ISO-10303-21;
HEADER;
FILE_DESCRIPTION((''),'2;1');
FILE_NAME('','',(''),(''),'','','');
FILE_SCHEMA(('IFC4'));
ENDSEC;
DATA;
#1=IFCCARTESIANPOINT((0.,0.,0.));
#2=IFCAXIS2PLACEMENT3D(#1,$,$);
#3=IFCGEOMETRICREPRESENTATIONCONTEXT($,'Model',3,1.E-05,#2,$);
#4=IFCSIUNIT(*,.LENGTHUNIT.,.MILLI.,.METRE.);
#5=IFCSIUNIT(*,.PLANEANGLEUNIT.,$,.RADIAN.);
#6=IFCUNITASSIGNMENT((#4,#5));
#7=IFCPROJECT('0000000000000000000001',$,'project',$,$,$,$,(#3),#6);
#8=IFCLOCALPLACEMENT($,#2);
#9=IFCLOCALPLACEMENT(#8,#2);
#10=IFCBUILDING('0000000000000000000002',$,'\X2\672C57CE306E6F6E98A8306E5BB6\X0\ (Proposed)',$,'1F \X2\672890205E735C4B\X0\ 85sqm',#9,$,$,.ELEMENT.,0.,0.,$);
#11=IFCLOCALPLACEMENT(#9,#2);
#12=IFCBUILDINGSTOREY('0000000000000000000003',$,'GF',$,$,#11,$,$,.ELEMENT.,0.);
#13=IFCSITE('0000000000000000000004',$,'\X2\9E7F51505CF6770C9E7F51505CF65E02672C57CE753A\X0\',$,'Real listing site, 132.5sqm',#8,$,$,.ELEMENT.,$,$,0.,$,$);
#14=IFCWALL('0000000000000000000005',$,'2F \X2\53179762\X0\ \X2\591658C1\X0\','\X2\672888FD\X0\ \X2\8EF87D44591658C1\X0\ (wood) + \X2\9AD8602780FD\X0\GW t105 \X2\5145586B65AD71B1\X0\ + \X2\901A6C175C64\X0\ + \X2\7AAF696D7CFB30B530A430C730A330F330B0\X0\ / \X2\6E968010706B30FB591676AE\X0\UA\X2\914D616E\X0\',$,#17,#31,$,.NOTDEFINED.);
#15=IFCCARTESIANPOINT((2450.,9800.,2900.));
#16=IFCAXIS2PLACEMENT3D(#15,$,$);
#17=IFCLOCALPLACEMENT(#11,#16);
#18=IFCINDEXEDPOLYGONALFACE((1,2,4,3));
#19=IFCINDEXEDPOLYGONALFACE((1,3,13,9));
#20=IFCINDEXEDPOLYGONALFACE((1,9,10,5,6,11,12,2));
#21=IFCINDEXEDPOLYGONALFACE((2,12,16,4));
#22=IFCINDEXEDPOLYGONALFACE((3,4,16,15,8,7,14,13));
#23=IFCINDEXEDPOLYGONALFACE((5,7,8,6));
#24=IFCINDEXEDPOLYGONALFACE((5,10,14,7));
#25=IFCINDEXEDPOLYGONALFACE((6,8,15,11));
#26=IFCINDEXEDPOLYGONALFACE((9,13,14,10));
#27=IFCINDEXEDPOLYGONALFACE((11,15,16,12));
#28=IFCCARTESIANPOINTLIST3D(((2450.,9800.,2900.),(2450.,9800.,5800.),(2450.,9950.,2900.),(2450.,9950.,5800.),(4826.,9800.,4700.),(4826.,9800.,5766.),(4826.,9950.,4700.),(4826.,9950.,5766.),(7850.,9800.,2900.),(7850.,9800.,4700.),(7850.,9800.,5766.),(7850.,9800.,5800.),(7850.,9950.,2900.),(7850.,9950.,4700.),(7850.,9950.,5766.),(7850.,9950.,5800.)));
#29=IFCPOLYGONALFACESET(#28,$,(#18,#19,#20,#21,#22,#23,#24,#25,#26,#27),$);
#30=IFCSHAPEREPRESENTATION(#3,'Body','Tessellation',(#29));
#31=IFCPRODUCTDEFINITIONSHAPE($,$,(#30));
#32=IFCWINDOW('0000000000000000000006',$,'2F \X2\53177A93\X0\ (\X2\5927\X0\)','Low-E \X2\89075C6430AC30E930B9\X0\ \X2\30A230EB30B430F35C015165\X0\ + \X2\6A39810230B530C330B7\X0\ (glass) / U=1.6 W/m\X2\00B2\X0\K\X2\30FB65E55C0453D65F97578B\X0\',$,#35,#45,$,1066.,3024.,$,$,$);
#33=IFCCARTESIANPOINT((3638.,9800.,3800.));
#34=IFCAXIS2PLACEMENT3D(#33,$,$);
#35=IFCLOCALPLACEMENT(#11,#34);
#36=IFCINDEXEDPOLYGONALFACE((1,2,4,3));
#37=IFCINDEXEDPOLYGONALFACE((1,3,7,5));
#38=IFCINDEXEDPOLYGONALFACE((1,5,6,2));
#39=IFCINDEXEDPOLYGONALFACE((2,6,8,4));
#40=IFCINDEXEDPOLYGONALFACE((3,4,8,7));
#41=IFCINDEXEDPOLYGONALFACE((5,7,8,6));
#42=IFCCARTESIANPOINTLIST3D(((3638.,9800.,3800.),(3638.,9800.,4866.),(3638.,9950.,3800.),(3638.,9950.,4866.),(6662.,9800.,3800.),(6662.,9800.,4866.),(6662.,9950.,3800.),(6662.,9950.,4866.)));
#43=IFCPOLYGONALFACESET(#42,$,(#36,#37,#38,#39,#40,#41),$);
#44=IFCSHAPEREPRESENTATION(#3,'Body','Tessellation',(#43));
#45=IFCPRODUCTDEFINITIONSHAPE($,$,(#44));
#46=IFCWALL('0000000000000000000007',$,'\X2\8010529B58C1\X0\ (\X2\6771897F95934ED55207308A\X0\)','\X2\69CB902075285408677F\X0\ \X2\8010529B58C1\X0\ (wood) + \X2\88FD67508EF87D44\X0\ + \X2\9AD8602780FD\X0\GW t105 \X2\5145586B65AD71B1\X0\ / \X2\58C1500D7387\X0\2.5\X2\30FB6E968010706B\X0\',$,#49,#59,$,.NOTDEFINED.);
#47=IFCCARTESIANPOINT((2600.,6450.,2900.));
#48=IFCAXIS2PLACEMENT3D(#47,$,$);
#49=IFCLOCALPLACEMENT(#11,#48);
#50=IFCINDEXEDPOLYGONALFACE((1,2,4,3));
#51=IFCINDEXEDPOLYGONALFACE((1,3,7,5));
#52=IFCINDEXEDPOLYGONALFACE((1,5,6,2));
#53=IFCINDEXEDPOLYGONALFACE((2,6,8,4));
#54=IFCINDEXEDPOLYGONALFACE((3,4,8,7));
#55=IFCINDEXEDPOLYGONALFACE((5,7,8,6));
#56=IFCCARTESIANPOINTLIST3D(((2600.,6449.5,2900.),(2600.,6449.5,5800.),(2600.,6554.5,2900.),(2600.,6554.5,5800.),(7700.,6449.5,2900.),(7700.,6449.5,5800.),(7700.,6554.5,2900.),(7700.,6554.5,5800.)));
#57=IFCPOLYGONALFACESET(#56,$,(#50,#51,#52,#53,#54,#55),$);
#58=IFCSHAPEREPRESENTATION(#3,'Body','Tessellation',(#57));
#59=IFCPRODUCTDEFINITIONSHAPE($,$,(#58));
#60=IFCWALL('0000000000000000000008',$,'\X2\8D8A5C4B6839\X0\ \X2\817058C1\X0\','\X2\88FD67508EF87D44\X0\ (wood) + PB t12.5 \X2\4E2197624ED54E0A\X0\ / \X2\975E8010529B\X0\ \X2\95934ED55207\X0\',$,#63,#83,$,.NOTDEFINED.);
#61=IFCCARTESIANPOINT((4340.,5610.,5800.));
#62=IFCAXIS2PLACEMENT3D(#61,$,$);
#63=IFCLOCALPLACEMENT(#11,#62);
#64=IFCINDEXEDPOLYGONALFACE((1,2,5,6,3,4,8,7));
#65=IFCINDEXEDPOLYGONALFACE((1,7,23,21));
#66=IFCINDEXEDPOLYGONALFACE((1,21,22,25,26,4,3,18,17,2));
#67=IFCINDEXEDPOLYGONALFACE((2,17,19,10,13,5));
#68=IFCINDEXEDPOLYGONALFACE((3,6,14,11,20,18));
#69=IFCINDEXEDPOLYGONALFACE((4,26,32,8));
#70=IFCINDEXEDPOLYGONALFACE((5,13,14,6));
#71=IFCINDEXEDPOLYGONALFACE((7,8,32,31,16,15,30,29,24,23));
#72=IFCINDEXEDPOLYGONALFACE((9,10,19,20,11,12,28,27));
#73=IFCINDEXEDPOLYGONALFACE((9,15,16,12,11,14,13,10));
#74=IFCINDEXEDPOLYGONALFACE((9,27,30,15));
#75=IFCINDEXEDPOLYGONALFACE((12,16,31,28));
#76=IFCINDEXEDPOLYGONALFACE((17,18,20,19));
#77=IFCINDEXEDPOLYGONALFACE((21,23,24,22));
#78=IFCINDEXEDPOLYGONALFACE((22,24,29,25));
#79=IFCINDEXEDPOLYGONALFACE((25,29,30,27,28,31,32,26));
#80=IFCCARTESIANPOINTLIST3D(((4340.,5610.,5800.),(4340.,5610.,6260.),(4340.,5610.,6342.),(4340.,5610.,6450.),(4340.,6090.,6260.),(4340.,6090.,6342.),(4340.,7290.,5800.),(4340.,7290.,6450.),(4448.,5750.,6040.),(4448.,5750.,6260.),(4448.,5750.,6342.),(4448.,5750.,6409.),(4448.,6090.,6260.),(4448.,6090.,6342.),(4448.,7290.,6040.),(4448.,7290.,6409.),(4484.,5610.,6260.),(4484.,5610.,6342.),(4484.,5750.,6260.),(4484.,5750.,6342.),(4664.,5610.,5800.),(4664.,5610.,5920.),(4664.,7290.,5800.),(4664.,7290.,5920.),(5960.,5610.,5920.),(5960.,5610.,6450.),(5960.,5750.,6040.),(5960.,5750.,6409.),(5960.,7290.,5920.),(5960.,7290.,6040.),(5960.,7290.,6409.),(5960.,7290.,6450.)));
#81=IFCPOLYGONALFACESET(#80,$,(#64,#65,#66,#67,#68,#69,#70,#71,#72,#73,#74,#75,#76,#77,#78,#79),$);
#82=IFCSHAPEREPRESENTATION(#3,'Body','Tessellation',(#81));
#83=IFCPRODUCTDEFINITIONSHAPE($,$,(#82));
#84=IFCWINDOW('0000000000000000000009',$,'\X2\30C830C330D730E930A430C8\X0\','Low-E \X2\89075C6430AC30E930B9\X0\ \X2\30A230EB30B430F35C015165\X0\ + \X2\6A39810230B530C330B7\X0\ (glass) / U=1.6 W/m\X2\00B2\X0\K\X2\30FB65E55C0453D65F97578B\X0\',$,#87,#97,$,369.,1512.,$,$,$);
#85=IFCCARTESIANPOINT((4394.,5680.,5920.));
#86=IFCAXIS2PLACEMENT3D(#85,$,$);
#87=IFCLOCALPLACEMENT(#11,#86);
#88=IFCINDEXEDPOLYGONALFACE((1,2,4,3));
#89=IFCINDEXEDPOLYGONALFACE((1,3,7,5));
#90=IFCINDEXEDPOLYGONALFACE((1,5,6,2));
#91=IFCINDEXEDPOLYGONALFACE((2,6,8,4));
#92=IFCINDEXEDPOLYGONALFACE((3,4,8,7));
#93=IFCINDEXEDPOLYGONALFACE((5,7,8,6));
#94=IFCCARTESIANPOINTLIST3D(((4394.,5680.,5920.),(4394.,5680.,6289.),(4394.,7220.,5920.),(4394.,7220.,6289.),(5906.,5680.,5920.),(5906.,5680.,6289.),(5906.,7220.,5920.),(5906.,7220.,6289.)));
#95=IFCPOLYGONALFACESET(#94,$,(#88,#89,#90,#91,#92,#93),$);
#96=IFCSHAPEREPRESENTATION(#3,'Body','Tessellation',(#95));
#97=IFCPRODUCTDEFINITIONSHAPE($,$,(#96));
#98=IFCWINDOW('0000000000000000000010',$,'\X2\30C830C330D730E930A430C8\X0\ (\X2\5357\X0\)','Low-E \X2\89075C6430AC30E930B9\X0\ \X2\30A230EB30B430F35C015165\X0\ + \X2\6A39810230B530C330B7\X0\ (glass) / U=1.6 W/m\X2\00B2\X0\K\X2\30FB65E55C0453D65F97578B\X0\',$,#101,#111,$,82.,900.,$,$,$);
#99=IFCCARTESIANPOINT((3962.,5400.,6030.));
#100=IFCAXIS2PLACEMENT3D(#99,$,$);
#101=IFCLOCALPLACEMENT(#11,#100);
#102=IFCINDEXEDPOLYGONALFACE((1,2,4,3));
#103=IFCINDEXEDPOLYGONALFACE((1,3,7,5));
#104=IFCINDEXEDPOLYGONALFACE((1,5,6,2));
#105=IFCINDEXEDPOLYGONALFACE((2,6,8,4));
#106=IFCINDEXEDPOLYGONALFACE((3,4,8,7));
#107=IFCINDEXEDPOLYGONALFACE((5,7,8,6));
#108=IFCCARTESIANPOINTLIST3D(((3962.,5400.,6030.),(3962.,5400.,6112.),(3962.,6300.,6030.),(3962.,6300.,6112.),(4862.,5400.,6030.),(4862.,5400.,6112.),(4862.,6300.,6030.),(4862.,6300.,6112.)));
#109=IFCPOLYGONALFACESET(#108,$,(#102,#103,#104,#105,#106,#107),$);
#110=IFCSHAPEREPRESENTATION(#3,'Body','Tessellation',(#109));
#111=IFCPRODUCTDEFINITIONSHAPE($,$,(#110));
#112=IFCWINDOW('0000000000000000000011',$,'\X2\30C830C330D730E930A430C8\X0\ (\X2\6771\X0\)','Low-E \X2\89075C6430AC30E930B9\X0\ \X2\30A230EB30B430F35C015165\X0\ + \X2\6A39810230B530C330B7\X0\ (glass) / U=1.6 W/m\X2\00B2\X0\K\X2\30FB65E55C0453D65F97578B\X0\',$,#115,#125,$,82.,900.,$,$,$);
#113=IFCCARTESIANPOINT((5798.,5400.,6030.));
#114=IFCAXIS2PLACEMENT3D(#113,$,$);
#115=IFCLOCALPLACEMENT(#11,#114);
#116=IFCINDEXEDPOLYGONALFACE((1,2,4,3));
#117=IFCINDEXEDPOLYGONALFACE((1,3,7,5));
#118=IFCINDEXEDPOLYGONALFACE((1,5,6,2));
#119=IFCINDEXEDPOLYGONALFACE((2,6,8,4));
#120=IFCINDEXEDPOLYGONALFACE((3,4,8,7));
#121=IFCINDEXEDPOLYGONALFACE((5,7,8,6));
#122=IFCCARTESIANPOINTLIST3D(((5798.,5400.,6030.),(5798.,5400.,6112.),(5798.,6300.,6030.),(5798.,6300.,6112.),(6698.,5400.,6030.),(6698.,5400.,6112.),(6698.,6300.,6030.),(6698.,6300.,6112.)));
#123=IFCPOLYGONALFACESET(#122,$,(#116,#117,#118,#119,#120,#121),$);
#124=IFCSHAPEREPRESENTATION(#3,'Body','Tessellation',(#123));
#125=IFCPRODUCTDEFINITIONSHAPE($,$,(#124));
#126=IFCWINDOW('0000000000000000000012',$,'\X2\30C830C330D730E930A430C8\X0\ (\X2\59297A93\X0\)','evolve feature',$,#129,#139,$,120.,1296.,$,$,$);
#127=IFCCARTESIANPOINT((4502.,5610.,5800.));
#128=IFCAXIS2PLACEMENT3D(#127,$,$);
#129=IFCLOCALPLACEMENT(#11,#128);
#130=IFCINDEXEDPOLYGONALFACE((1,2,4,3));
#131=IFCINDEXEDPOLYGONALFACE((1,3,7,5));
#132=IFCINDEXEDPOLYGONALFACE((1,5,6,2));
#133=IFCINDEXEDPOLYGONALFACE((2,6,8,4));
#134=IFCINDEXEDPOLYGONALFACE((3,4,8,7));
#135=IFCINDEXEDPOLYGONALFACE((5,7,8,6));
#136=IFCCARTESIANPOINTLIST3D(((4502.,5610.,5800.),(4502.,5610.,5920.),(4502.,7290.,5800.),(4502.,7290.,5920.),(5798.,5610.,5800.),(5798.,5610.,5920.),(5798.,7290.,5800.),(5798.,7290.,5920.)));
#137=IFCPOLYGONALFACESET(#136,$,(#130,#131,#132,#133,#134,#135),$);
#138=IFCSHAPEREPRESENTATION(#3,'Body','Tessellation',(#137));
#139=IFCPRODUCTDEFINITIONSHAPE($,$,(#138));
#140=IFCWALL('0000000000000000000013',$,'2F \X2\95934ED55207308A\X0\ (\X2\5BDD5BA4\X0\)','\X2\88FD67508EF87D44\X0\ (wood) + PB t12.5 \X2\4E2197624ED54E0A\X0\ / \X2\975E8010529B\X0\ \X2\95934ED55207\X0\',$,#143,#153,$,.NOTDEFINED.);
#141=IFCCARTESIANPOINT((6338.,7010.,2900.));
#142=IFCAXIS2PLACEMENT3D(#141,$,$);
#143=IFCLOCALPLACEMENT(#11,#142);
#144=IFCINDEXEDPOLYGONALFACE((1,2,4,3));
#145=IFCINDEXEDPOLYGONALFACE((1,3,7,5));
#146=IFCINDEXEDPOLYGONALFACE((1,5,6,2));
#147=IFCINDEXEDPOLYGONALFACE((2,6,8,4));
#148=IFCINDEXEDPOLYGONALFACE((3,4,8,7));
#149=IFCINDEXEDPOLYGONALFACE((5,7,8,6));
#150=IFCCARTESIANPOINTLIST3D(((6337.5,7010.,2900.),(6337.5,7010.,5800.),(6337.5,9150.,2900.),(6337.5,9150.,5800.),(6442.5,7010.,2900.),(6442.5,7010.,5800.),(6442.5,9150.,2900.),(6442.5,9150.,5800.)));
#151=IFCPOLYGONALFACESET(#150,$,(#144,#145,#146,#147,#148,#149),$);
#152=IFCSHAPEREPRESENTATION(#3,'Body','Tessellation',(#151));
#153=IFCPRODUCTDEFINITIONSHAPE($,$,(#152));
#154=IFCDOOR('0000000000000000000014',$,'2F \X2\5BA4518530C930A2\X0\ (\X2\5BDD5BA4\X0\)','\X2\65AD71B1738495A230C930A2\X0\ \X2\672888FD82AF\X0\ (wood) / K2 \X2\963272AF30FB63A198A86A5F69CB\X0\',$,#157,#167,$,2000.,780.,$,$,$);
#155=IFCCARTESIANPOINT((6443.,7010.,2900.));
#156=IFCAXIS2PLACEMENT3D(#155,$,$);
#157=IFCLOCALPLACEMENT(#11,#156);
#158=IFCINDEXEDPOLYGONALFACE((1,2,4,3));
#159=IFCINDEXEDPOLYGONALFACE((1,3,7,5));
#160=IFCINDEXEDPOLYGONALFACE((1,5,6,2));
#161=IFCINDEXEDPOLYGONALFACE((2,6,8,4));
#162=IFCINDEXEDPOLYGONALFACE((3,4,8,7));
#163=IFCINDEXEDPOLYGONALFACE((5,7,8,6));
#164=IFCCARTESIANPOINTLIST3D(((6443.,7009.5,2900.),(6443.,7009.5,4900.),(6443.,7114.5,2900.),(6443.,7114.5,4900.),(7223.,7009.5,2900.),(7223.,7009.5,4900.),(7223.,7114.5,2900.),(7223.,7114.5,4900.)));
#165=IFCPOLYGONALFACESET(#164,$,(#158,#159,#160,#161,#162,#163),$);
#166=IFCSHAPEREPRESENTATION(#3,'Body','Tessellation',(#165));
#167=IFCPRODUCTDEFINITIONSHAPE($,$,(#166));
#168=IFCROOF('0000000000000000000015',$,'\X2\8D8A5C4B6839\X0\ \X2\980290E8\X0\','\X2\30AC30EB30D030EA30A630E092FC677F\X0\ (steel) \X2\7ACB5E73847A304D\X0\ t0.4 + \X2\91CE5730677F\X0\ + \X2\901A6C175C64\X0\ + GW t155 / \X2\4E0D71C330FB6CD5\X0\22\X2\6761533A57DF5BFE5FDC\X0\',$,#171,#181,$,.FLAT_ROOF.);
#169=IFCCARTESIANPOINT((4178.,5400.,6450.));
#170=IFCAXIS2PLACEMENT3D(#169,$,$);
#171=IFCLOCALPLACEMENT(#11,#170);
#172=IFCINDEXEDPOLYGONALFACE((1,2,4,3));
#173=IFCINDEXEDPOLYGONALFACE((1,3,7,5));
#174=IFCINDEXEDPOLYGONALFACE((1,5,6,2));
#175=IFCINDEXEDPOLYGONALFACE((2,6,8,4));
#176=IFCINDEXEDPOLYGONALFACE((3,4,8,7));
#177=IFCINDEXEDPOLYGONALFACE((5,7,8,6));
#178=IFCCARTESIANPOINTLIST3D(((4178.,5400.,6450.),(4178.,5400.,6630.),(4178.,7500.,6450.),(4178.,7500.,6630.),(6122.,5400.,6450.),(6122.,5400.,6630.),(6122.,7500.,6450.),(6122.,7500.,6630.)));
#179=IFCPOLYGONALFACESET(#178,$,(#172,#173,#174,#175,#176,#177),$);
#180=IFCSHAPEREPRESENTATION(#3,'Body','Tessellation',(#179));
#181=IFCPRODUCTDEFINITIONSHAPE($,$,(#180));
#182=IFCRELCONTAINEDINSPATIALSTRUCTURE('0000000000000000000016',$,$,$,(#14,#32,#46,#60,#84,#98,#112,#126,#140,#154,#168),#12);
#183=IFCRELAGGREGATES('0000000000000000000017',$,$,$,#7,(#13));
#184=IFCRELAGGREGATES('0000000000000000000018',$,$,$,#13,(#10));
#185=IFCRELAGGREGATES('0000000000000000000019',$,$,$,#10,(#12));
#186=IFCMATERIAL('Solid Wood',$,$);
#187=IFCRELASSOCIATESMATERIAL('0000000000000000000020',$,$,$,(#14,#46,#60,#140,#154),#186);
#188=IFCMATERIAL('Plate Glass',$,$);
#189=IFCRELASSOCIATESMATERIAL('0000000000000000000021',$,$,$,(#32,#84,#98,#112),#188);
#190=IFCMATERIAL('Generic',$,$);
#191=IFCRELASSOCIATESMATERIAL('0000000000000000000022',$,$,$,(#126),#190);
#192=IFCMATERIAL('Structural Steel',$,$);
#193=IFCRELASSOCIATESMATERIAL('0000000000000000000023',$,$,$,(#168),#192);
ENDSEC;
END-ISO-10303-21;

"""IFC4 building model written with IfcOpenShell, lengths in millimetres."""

from ifc_helpers import new_model, si_unit, frame, frame_2d, origin, place, context, project, spatial, rectangle, extrude, material, element, fill, save


model = new_model("IFC4")

# Units and contexts
model_context = context("Model", 3, precision=1e-05, world=origin())
ifc_project = project(units=[si_unit("LENGTHUNIT", "METRE", prefix="MILLI"), si_unit("PLANEANGLEUNIT", "RADIAN")], contexts=[model_context])

# Site, building, storey
site_placement = place(None, origin())
site = spatial("IfcSite", under=ifc_project, at=site_placement, Name="鹿児島県鹿児島市本城町", ObjectType="Real listing site, 132.5sqm", CompositionType="ELEMENT", RefElevation=0.0)
building_placement = place(site_placement, origin())
building = spatial("IfcBuilding", under=site, at=building_placement, Name="本城の潮風の家 (Proposed)", ObjectType="1F 木造平屋 85sqm", CompositionType="ELEMENT", ElevationOfRefHeight=0.0, ElevationOfTerrain=0.0)
storey_placement = place(building_placement, origin())
storey = spatial("IfcBuildingStorey", under=building, at=storey_placement, Name="GF", CompositionType="ELEMENT", Elevation=0.0)

# Wall, opening, window
ifc_material_1 = material(Name="Solid Wood")
wall_1_placement = place(storey_placement, frame((2450.0, 9800.0, 2900.0)))
wall_1 = element("IfcWall", 1, at=wall_1_placement, inside=storey, material=ifc_material_1, Name="2F 北面 外壁", Description="木製 軸組外壁 (wood) + 高性能GW t105 充填断熱 + 通気層 + 窯業系サイディング / 準耐火・外皮UA配慮", PredefinedType="NOTDEFINED", context=model_context, shape_type="SweptSolid", body=[
    extrude(rectangle(XDim=5400.0, YDim=150.0, at=frame_2d((2700.0, 75.0))), frame((2450.0, 9800.0, 2900.0)), (0.0, 0.0, 1.0), 2900.0),
])
opening_1_placement = place(storey_placement, frame((3638.0, 9800.0, 3800.0)))
opening_1 = element("IfcOpeningElement", 2, at=opening_1_placement, cuts=wall_1, PredefinedType="NOTDEFINED", context=model_context, shape_type="SweptSolid", body=[
    extrude(rectangle(XDim=3024.0, YDim=150.0, at=frame_2d((1512.0, 75.0))), frame((3638.0, 9800.0, 3800.0)), (0.0, 0.0, 1.0), 1066.0),
])
ifc_material_2 = material(Name="Plate Glass")
window_1_placement = place(storey_placement, frame((3638.0, 9800.0, 3800.0)))
window_1 = element("IfcWindow", 3, at=window_1_placement, inside=storey, material=ifc_material_2, Name="2F 北窓 (大)", Description="Low-E 複層ガラス アルゴン封入 + 樹脂サッシ (glass) / U=1.6 W/m²K・日射取得型", OverallHeight=1066.0, OverallWidth=3024.0, context=model_context, shape_type="SweptSolid", body=[
    extrude(rectangle(XDim=3024.0, YDim=150.0, at=frame_2d((1512.0, 75.0))), frame((3638.0, 9800.0, 3800.0)), (0.0, 0.0, 1.0), 1066.0),
])
fill(opening_1, window_1)

# Wall
wall_2_placement = place(storey_placement, frame((2600.0, 6450.0, 2900.0)))
element("IfcWall", 4, at=wall_2_placement, inside=storey, material=ifc_material_1, Name="耐力壁 (東西間仕切り)", Description="構造用合板 耐力壁 (wood) + 製材軸組 + 高性能GW t105 充填断熱 / 壁倍率2.5・準耐火", PredefinedType="NOTDEFINED", context=model_context, shape_type="SweptSolid", body=[
    extrude(rectangle(XDim=5100.0, YDim=105.0, at=frame_2d((2550.0, 52.0))), frame((2600.0, 6450.0, 2900.0)), (0.0, 0.0, 1.0), 2900.0),
])

# Wall, openings, windows
wall_3_placement = place(storey_placement, frame((4340.0, 5610.0, 5800.0)))
wall_3 = element("IfcWall", 5, at=wall_3_placement, inside=storey, material=ifc_material_1, Name="越屋根 腰壁", Description="製材軸組 (wood) + PB t12.5 両面仕上 / 非耐力 間仕切", PredefinedType="NOTDEFINED", context=model_context, shape_type="SweptSolid", body=[
    extrude(rectangle(XDim=1620.0, YDim=1680.0, at=frame_2d((810.0, 840.0))), frame((4340.0, 5610.0, 5800.0)), (0.0, 0.0, 1.0), 650.0),
])
opening_2_placement = place(storey_placement, frame((4394.0, 5680.0, 5920.0)))
opening_2 = element("IfcOpeningElement", 6, at=opening_2_placement, cuts=wall_3, PredefinedType="NOTDEFINED", context=model_context, shape_type="SweptSolid", body=[
    extrude(rectangle(XDim=1512.0, YDim=1540.0, at=frame_2d((756.0, 770.0))), frame((4394.0, 5680.0, 5920.0)), (0.0, 0.0, 1.0), 369.0),
])
opening_3_placement = place(storey_placement, frame((3962.0, 5400.0, 6030.0)))
opening_3 = element("IfcOpeningElement", 7, at=opening_3_placement, cuts=wall_3, PredefinedType="NOTDEFINED", context=model_context, shape_type="SweptSolid", body=[
    extrude(rectangle(XDim=900.0, YDim=900.0, at=frame_2d((450.0, 450.0))), frame((3962.0, 5400.0, 6030.0)), (0.0, 0.0, 1.0), 82.0),
])
opening_4_placement = place(storey_placement, frame((5798.0, 5400.0, 6030.0)))
opening_4 = element("IfcOpeningElement", 8, at=opening_4_placement, cuts=wall_3, PredefinedType="NOTDEFINED", context=model_context, shape_type="SweptSolid", body=[
    extrude(rectangle(XDim=900.0, YDim=900.0, at=frame_2d((450.0, 450.0))), frame((5798.0, 5400.0, 6030.0)), (0.0, 0.0, 1.0), 82.0),
])
opening_5_placement = place(storey_placement, frame((4502.0, 5610.0, 5800.0)))
opening_5 = element("IfcOpeningElement", 9, at=opening_5_placement, cuts=wall_3, PredefinedType="NOTDEFINED", context=model_context, shape_type="SweptSolid", body=[
    extrude(rectangle(XDim=1296.0, YDim=1680.0, at=frame_2d((648.0, 840.0))), frame((4502.0, 5610.0, 5800.0)), (0.0, 0.0, 1.0), 120.0),
])
window_2_placement = place(storey_placement, frame((4394.0, 5680.0, 5920.0)))
window_2 = element("IfcWindow", 10, at=window_2_placement, inside=storey, material=ifc_material_2, Name="トップライト", Description="Low-E 複層ガラス アルゴン封入 + 樹脂サッシ (glass) / U=1.6 W/m²K・日射取得型", OverallHeight=369.0, OverallWidth=1512.0, context=model_context, shape_type="SweptSolid", body=[
    extrude(rectangle(XDim=1512.0, YDim=1540.0, at=frame_2d((756.0, 770.0))), frame((4394.0, 5680.0, 5920.0)), (0.0, 0.0, 1.0), 369.0),
])
fill(opening_2, window_2)
window_3_placement = place(storey_placement, frame((3962.0, 5400.0, 6030.0)))
window_3 = element("IfcWindow", 11, at=window_3_placement, inside=storey, material=ifc_material_2, Name="トップライト (南)", Description="Low-E 複層ガラス アルゴン封入 + 樹脂サッシ (glass) / U=1.6 W/m²K・日射取得型", OverallHeight=82.0, OverallWidth=900.0, context=model_context, shape_type="SweptSolid", body=[
    extrude(rectangle(XDim=900.0, YDim=900.0, at=frame_2d((450.0, 450.0))), frame((3962.0, 5400.0, 6030.0)), (0.0, 0.0, 1.0), 82.0),
])
fill(opening_3, window_3)
window_4_placement = place(storey_placement, frame((5798.0, 5400.0, 6030.0)))
window_4 = element("IfcWindow", 12, at=window_4_placement, inside=storey, material=ifc_material_2, Name="トップライト (東)", Description="Low-E 複層ガラス アルゴン封入 + 樹脂サッシ (glass) / U=1.6 W/m²K・日射取得型", OverallHeight=82.0, OverallWidth=900.0, context=model_context, shape_type="SweptSolid", body=[
    extrude(rectangle(XDim=900.0, YDim=900.0, at=frame_2d((450.0, 450.0))), frame((5798.0, 5400.0, 6030.0)), (0.0, 0.0, 1.0), 82.0),
])
fill(opening_4, window_4)
ifc_material_3 = material(Name="Generic")
window_5_placement = place(storey_placement, frame((4502.0, 5610.0, 5800.0)))
window_5 = element("IfcWindow", 13, at=window_5_placement, inside=storey, material=ifc_material_3, Name="トップライト (天窓)", Description="evolve feature", OverallHeight=120.0, OverallWidth=1296.0, context=model_context, shape_type="SweptSolid", body=[
    extrude(rectangle(XDim=1296.0, YDim=1680.0, at=frame_2d((648.0, 840.0))), frame((4502.0, 5610.0, 5800.0)), (0.0, 0.0, 1.0), 120.0),
])
fill(opening_5, window_5)

# Wall
wall_4_placement = place(storey_placement, frame((6338.0, 7010.0, 2900.0)))
element("IfcWall", 14, at=wall_4_placement, inside=storey, material=ifc_material_1, Name="2F 間仕切り (寝室)", Description="製材軸組 (wood) + PB t12.5 両面仕上 / 非耐力 間仕切", PredefinedType="NOTDEFINED", context=model_context, shape_type="SweptSolid", body=[
    extrude(rectangle(XDim=105.0, YDim=2140.0, at=frame_2d((52.0, 1070.0))), frame((6338.0, 7010.0, 2900.0)), (0.0, 0.0, 1.0), 2900.0),
])

# Door
door_placement = place(storey_placement, frame((6443.0, 7010.0, 2900.0)))
element("IfcDoor", 15, at=door_placement, inside=storey, material=ifc_material_1, Name="2F 室内ドア (寝室)", Description="断熱玄関ドア 木製芯 (wood) / K2 防犯・採風機構", OverallHeight=2000.0, OverallWidth=780.0, context=model_context, shape_type="SweptSolid", body=[
    extrude(rectangle(XDim=780.0, YDim=105.0, at=frame_2d((390.0, 52.0))), frame((6443.0, 7010.0, 2900.0)), (0.0, 0.0, 1.0), 2000.0),
])

# Roof
ifc_material_4 = material(Name="Structural Steel")
roof_placement = place(storey_placement, frame((4178.0, 5400.0, 6450.0)))
element("IfcRoof", 16, at=roof_placement, inside=storey, material=ifc_material_4, Name="越屋根 頂部", Description="ガルバリウム鋼板 (steel) 立平葺き t0.4 + 野地板 + 通気層 + GW t155 / 不燃・法22条区域対応", PredefinedType="FLAT_ROOF", context=model_context, shape_type="SweptSolid", body=[
    extrude(rectangle(XDim=1944.0, YDim=2100.0, at=frame_2d((972.0, 1050.0))), frame((4178.0, 5400.0, 6450.0)), (0.0, 0.0, 1.0), 180.0),
])

save(model, "model.ifc")
